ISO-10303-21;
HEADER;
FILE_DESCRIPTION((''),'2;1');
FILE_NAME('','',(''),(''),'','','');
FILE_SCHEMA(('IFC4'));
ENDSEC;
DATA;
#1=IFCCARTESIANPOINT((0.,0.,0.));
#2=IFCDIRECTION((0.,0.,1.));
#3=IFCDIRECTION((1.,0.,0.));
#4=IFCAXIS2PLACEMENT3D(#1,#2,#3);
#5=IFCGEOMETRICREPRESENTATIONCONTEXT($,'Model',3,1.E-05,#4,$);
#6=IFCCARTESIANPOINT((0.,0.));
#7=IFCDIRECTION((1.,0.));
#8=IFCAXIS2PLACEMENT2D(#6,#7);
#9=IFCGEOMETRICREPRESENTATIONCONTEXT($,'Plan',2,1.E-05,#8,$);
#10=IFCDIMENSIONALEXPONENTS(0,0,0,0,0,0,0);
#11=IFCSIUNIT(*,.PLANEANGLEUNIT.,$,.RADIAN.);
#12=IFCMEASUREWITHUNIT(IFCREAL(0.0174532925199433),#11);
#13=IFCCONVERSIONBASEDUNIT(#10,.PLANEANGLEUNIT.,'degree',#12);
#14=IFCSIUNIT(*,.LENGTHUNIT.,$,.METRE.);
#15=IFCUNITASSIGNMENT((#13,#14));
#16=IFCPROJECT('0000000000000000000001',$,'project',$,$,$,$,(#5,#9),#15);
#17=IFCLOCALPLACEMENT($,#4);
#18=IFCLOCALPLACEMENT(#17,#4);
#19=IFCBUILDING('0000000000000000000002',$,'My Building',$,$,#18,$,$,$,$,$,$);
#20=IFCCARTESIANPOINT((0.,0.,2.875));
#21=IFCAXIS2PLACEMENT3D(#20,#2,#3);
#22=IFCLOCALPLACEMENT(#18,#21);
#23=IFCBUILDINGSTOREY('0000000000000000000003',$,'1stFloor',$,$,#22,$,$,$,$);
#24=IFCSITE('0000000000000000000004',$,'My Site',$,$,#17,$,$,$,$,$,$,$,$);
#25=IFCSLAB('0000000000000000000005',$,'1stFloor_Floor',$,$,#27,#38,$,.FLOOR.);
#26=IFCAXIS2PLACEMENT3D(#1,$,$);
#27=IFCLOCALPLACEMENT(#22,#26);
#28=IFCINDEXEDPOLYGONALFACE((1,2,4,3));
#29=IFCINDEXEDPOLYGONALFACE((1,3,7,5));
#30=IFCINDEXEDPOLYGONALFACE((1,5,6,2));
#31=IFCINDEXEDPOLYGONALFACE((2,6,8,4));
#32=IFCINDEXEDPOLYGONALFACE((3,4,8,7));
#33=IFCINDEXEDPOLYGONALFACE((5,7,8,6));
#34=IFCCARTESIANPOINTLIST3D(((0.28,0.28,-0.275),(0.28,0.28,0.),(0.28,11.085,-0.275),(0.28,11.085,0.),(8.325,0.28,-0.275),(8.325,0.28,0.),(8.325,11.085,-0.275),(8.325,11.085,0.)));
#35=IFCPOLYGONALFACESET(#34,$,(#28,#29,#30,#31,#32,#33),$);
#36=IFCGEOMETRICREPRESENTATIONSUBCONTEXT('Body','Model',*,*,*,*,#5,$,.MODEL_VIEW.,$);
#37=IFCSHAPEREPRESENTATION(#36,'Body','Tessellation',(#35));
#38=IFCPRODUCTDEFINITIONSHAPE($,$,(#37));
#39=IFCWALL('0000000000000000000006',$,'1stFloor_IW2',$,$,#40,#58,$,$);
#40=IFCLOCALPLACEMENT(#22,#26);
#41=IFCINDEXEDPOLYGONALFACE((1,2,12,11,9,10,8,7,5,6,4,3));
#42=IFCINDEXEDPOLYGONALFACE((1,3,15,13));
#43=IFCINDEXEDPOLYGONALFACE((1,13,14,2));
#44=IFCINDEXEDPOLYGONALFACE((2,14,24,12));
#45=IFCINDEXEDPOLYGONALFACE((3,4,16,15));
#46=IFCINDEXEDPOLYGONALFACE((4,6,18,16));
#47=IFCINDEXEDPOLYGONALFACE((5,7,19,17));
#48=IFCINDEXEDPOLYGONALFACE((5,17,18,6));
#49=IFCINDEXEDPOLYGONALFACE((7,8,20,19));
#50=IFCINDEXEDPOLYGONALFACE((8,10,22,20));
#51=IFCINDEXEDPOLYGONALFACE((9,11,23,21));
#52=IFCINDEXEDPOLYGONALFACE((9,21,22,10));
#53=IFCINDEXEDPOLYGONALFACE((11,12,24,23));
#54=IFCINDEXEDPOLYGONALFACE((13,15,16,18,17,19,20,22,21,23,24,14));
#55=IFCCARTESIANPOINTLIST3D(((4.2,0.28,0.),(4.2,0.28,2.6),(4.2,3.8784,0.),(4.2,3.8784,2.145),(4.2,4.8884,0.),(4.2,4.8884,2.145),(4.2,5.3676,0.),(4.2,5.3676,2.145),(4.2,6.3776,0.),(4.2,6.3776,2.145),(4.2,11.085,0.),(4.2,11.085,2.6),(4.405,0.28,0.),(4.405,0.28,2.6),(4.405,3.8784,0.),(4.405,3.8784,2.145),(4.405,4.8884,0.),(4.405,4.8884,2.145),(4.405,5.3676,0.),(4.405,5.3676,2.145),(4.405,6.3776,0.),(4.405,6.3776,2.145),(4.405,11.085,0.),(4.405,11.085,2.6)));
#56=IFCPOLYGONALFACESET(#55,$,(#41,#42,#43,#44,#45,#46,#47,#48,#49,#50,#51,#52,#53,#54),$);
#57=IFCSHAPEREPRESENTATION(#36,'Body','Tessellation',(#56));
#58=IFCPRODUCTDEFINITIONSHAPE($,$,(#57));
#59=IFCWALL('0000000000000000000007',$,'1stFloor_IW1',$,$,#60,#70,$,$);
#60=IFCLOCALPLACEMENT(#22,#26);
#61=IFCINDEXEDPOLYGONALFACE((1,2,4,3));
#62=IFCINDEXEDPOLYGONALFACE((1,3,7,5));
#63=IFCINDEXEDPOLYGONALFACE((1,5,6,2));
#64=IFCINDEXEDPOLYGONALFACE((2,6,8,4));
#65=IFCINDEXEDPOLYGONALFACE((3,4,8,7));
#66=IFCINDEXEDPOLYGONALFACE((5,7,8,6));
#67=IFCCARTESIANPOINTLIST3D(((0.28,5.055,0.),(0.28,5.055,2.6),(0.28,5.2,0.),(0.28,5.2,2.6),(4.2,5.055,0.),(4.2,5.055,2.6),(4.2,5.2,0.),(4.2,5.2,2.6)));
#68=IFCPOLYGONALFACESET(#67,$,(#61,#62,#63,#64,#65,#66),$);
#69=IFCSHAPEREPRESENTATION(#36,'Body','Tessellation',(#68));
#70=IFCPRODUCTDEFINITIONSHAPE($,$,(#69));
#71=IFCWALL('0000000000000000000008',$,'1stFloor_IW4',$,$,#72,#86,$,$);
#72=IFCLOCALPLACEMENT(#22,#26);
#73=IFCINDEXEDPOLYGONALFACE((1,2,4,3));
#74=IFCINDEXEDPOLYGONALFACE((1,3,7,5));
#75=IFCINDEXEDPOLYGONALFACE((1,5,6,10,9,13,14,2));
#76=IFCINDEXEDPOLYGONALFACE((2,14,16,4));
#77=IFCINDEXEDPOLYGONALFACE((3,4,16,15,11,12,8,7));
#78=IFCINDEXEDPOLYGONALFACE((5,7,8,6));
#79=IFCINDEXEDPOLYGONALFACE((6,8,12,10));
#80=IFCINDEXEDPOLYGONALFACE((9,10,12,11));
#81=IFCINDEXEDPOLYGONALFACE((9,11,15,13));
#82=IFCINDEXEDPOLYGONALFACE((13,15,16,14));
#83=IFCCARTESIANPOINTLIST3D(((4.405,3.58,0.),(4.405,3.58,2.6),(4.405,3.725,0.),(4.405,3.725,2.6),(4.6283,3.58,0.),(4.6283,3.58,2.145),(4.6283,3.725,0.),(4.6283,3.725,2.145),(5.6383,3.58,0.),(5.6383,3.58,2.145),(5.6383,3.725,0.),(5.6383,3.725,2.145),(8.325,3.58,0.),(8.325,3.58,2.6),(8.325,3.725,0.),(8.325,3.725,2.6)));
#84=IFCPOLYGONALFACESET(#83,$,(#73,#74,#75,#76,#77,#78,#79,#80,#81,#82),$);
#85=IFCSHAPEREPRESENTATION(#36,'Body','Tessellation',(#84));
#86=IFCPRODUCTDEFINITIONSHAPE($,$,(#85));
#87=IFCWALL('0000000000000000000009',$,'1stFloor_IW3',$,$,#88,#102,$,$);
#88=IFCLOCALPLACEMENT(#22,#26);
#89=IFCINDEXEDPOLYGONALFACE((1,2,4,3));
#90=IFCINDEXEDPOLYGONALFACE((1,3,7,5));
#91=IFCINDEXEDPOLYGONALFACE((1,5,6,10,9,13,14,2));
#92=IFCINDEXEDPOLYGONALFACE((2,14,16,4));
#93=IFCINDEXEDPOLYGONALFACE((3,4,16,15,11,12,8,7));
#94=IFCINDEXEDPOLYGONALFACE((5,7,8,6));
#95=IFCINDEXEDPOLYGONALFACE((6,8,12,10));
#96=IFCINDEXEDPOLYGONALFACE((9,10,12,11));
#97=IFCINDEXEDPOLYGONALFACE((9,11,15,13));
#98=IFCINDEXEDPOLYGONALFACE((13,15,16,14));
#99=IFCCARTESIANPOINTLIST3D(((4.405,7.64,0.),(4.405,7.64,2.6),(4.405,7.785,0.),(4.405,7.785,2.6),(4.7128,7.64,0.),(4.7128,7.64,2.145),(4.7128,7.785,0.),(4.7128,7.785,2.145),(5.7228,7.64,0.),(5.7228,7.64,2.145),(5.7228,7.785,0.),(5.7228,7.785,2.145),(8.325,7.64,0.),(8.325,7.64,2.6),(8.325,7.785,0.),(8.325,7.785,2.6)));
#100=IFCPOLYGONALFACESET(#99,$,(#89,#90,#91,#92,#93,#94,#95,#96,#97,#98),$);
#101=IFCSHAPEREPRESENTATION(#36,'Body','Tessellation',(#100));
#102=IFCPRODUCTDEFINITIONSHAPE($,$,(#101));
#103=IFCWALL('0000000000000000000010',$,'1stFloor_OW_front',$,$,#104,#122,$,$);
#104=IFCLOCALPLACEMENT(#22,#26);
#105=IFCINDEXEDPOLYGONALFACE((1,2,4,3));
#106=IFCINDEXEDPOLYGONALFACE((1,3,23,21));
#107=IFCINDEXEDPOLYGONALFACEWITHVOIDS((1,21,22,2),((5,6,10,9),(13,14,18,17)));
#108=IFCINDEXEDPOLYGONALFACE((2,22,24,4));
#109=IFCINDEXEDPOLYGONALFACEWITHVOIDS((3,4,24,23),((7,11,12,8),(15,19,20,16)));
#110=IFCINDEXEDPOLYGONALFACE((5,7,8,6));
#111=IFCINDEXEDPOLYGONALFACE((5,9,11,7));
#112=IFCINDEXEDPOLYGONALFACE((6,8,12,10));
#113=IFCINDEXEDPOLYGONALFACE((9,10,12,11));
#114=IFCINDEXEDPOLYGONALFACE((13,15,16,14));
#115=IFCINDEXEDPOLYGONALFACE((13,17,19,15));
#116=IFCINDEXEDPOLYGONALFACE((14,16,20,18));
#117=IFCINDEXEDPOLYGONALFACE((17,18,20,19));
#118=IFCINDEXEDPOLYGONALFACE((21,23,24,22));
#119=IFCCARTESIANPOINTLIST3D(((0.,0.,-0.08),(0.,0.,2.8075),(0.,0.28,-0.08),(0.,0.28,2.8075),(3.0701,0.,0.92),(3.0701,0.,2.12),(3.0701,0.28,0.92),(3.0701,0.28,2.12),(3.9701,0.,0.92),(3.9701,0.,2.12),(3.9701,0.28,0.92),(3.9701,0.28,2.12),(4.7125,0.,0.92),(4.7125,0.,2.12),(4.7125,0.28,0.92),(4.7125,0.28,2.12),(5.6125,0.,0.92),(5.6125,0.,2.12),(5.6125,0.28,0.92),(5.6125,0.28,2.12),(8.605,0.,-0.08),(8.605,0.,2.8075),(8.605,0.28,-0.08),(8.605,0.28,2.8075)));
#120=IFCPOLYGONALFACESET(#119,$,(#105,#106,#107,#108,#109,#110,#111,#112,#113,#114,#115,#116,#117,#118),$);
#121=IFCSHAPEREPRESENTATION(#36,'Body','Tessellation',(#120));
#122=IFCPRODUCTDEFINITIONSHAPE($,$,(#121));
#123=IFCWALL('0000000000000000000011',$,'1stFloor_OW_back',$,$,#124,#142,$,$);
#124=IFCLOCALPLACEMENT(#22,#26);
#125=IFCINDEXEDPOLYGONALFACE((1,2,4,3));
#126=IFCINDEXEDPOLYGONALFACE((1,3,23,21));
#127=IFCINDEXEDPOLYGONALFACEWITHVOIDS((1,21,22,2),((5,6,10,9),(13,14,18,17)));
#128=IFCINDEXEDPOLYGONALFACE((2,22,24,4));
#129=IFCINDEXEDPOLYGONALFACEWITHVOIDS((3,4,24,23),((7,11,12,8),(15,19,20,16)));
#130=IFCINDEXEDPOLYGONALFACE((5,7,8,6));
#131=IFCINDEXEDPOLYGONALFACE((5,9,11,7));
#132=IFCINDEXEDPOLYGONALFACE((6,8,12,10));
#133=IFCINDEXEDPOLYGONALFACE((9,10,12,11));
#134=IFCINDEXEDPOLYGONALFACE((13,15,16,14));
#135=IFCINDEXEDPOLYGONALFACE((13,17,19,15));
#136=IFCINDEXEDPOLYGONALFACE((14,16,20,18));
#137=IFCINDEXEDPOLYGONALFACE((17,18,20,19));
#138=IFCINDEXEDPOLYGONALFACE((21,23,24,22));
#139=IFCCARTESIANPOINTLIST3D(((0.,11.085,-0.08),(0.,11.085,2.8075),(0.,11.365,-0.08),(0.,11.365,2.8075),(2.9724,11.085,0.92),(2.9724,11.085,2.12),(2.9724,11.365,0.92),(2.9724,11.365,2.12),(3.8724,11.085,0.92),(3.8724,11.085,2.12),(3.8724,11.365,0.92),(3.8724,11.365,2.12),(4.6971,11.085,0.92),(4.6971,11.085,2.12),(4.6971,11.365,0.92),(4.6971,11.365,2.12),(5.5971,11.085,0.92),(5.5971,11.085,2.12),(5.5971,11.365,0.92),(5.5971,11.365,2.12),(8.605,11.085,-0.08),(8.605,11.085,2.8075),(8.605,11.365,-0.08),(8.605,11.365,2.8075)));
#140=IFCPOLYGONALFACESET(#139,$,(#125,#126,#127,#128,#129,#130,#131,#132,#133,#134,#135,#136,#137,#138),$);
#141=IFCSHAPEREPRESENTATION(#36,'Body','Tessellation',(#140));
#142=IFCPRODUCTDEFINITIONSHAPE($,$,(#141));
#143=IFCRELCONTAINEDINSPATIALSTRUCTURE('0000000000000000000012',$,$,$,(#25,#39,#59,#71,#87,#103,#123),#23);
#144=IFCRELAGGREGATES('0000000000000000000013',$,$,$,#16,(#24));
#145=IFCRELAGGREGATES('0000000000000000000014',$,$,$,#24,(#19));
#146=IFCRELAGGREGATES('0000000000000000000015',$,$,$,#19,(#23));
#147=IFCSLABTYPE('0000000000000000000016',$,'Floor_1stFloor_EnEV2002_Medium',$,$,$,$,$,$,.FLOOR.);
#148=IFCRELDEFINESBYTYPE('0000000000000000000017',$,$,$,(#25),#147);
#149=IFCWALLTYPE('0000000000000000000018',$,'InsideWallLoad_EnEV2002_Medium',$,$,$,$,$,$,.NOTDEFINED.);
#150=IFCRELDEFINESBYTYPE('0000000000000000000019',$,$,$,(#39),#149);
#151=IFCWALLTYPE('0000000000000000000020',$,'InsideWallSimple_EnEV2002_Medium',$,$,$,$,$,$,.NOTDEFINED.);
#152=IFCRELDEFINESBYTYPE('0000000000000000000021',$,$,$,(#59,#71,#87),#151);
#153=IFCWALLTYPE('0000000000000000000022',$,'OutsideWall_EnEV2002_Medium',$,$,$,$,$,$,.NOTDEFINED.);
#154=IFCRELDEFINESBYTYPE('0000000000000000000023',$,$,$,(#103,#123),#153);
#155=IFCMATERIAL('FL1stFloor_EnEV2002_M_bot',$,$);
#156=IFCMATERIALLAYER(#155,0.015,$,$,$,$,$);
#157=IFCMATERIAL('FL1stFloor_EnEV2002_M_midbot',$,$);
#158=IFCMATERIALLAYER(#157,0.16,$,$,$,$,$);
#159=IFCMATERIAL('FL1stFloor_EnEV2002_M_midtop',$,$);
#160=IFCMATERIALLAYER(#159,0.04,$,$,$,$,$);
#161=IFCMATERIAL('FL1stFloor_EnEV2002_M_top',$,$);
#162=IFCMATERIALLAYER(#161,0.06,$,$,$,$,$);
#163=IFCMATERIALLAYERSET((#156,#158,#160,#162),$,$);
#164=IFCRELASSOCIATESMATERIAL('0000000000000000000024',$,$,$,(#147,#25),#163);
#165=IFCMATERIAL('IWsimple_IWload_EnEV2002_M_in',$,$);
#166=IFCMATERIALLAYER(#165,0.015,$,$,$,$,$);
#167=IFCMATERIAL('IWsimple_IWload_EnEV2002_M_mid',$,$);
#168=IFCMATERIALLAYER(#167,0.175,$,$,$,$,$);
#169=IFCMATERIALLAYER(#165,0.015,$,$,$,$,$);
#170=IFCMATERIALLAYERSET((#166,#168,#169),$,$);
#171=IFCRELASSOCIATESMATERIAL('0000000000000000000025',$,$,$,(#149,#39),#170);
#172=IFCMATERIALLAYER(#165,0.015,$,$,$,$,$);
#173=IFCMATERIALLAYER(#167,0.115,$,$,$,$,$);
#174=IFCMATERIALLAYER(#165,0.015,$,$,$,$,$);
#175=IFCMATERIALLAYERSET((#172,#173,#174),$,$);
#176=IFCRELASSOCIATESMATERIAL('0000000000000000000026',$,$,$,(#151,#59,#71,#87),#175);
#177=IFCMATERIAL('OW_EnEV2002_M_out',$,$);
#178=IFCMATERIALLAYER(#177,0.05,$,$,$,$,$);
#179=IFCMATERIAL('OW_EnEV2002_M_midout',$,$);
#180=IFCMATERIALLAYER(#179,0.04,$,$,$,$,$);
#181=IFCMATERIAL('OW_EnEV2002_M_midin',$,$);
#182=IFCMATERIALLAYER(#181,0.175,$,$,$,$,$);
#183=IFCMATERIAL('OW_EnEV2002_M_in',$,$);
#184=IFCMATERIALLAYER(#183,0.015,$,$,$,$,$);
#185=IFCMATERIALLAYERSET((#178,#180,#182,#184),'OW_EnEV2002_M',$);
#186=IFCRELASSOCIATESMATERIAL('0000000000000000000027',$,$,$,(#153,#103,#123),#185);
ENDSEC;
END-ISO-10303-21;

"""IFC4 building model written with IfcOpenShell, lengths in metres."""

from ifc_helpers import new_model, entity, si_unit, converted_unit, frame, origin_with_axes, origin_2d_with_axis, place, context, subcontext, project, spatial, line, indexed_curve, outline, extrude, source, transform, mapped, material, layer, layer_set, layer_usage, type_object, element, save


model = new_model("IFC4")

# Units and contexts
model_context = context("Model", 3, precision=1e-05, world=origin_with_axes())
plan_context = context("Plan", 2, precision=1e-05, world=origin_2d_with_axis())
body_context = subcontext(model_context, "Body", "Model", "MODEL_VIEW")
ifc_project = project(units=[converted_unit("PLANEANGLEUNIT", "degree", entity("IfcReal", 0.0174532925199433), si_unit("PLANEANGLEUNIT", "RADIAN"), dimensions=[0, 0, 0, 0, 0, 0, 0]), si_unit("LENGTHUNIT", "METRE")], contexts=[model_context, plan_context])

# Site, building, storey
site_placement = place(None, origin_with_axes())
site = spatial("IfcSite", under=ifc_project, at=site_placement, Name="My Site")
building_placement = place(site_placement, origin_with_axes())
building = spatial("IfcBuilding", under=site, at=building_placement, Name="My Building")
storey_placement = place(building_placement, frame((0.0, 0.0, 2.875), z_axis=(0.0, 0.0, 1.0), x_axis=(1.0, 0.0, 0.0)))
storey = spatial("IfcBuildingStorey", under=building, at=storey_placement, Name="1stFloor")

# Slab
ifc_material_1 = material(Name="FL1stFloor_EnEV2002_M_bot")
ifc_layer_1 = layer(ifc_material_1, 0.015)
ifc_material_2 = material(Name="FL1stFloor_EnEV2002_M_midbot")
ifc_layer_2 = layer(ifc_material_2, 0.16)
ifc_material_3 = material(Name="FL1stFloor_EnEV2002_M_midtop")
ifc_layer_3 = layer(ifc_material_3, 0.04)
ifc_material_4 = material(Name="FL1stFloor_EnEV2002_M_top")
ifc_layer_4 = layer(ifc_material_4, 0.06)
ifc_layer_set_1 = layer_set([ifc_layer_1, ifc_layer_2, ifc_layer_3, ifc_layer_4])
ifc_layer_usage_1 = layer_usage(ifc_layer_set_1, "AXIS3", "POSITIVE", 0.0)
slab_type = type_object("IfcSlabType", Name="Floor_1stFloor_EnEV2002_Medium", PredefinedType="FLOOR", material=ifc_layer_set_1)
slab_placement = place(storey_placement, frame((0.28, 0.28, -0.275), z_axis=(0.0, 0.0, 1.0), x_axis=(1.0, 0.0, 0.0)))
element("IfcSlab", 1, at=slab_placement, inside=storey, type_object=slab_type, material=ifc_layer_usage_1, Name="1stFloor_Floor", PredefinedType="FLOOR", context=body_context, shape_type="SweptSolid", body=[
    extrude(outline(indexed_curve([(0.0, 0.0), (8.045, 0.0), (8.045, 10.805), (0.0, 10.805)], segments=[line(4, 1), line(1, 2), line(2, 3), line(3, 4)], self_intersect=False)), None, (0.0, 0.0, 1.0), 0.275),
])

# Wall, openings
ifc_material_5 = material(Name="IWsimple_IWload_EnEV2002_M_in")
ifc_layer_5 = layer(ifc_material_5, 0.015)
ifc_material_6 = material(Name="IWsimple_IWload_EnEV2002_M_mid")
ifc_layer_6 = layer(ifc_material_6, 0.175)
ifc_layer_7 = layer(ifc_material_5, 0.015)
ifc_layer_set_2 = layer_set([ifc_layer_5, ifc_layer_6, ifc_layer_7])
ifc_layer_usage_2 = layer_usage(ifc_layer_set_2, "AXIS2", "POSITIVE", 0.0)
wall_type_1 = type_object("IfcWallType", Name="InsideWallLoad_EnEV2002_Medium", PredefinedType="NOTDEFINED", material=ifc_layer_set_2)
wall_1_placement = place(storey_placement, frame((4.405, 0.28, 0.0), z_axis=(0.0, 0.0, 1.0), x_axis=(0.0, 1.0, 0.0)))
wall_1 = element("IfcWall", 2, at=wall_1_placement, inside=storey, type_object=wall_type_1, material=ifc_layer_usage_2, Name="1stFloor_IW2", context=body_context, shape_type="SweptSolid", body=[
    extrude(outline(indexed_curve([(0.0, 0.0), (0.0, 0.205), (10.805, 0.205), (10.805, 0.0), (0.0, 0.0)], self_intersect=False)), origin_with_axes(), (0.0, 0.0, 1.0), 2.6),
])
shared_shape_1 = source(origin_with_axes(), body_context, "Body", "SweptSolid", [
    extrude(outline(indexed_curve([(0.0, 0.0), (1.01, 0.0), (1.01, 2.145), (0.0, 2.145)], segments=[line(1, 2, 3, 4, 1)])), frame((0.0, -0.1, 0.0), z_axis=(0.0, -1.0, 0.0), x_axis=(1.0, 0.0, 0.0)), (0.0, 0.0, -1.0), 0.48),
])
opening_1_placement = place(wall_1_placement, frame((3.5984, 0.0, 0.0), z_axis=(0.0, 0.0, 1.0), x_axis=(1.0, 0.0, 0.0)))
element("IfcOpeningElement", 3, at=opening_1_placement, cuts=wall_1, PredefinedType="OPENING", context=body_context, shape_type="MappedRepresentation", body=[
    mapped(shared_shape_1, transform((0.0, 0.0, 0.0), x_axis=(1.0, 0.0, 0.0), y_axis=(0.0, 1.0, 0.0), z_axis=(0.0, 0.0, 1.0), scale=1.0)),
])
opening_2_placement = place(wall_1_placement, frame((5.0876, 0.0, 0.0), z_axis=(0.0, 0.0, 1.0), x_axis=(1.0, 0.0, 0.0)))
element("IfcOpeningElement", 4, at=opening_2_placement, cuts=wall_1, PredefinedType="OPENING", context=body_context, shape_type="MappedRepresentation", body=[
    mapped(shared_shape_1, transform((0.0, 0.0, 0.0), x_axis=(1.0, 0.0, 0.0), y_axis=(0.0, 1.0, 0.0), z_axis=(0.0, 0.0, 1.0), scale=1.0)),
])

# Wall
ifc_layer_8 = layer(ifc_material_5, 0.015)
ifc_layer_9 = layer(ifc_material_6, 0.115)
ifc_layer_10 = layer(ifc_material_5, 0.015)
ifc_layer_set_3 = layer_set([ifc_layer_8, ifc_layer_9, ifc_layer_10])
ifc_layer_usage_3 = layer_usage(ifc_layer_set_3, "AXIS2", "POSITIVE", 0.0)
wall_type_2 = type_object("IfcWallType", Name="InsideWallSimple_EnEV2002_Medium", PredefinedType="NOTDEFINED", material=ifc_layer_set_3)
wall_2_placement = place(storey_placement, frame((0.28, 5.055, 0.0), z_axis=(0.0, 0.0, 1.0), x_axis=(1.0, 0.0, 0.0)))
element("IfcWall", 5, at=wall_2_placement, inside=storey, type_object=wall_type_2, material=ifc_layer_usage_3, Name="1stFloor_IW1", context=body_context, shape_type="SweptSolid", body=[
    extrude(outline(indexed_curve([(0.0, 0.0), (0.0, 0.145), (3.92, 0.145), (3.92, 0.0), (0.0, 0.0)], self_intersect=False)), origin_with_axes(), (0.0, 0.0, 1.0), 2.6),
])

# Walls, openings
ifc_layer_usage_4 = layer_usage(ifc_layer_set_3, "AXIS2", "POSITIVE", 0.0)
wall_3_placement = place(storey_placement, frame((4.405, 3.58, 0.0), z_axis=(0.0, 0.0, 1.0), x_axis=(1.0, 0.0, 0.0)))
wall_3 = element("IfcWall", 6, at=wall_3_placement, inside=storey, type_object=wall_type_2, material=ifc_layer_usage_4, Name="1stFloor_IW4", context=body_context, shape_type="SweptSolid", body=[
    extrude(outline(indexed_curve([(0.0, 0.0), (0.0, 0.145), (3.92, 0.145), (3.92, 0.0), (0.0, 0.0)], self_intersect=False)), origin_with_axes(), (0.0, 0.0, 1.0), 2.6),
])
opening_3_placement = place(wall_3_placement, frame((0.2233, 0.0, 0.0), z_axis=(0.0, 0.0, 1.0), x_axis=(1.0, 0.0, 0.0)))
element("IfcOpeningElement", 7, at=opening_3_placement, cuts=wall_3, PredefinedType="OPENING", context=body_context, shape_type="MappedRepresentation", body=[
    mapped(shared_shape_1, transform((0.0, 0.0, 0.0), x_axis=(1.0, 0.0, 0.0), y_axis=(0.0, 1.0, 0.0), z_axis=(0.0, 0.0, 1.0), scale=1.0)),
])
ifc_layer_usage_5 = layer_usage(ifc_layer_set_3, "AXIS2", "POSITIVE", 0.0)
wall_4_placement = place(storey_placement, frame((4.405, 7.64, 0.0), z_axis=(0.0, 0.0, 1.0), x_axis=(1.0, 0.0, 0.0)))
wall_4 = element("IfcWall", 8, at=wall_4_placement, inside=storey, type_object=wall_type_2, material=ifc_layer_usage_5, Name="1stFloor_IW3", context=body_context, shape_type="SweptSolid", body=[
    extrude(outline(indexed_curve([(0.0, 0.0), (0.0, 0.145), (3.92, 0.145), (3.92, 0.0), (0.0, 0.0)], self_intersect=False)), origin_with_axes(), (0.0, 0.0, 1.0), 2.6),
])
opening_4_placement = place(wall_4_placement, frame((0.3078, 0.0, 0.0), z_axis=(0.0, 0.0, 1.0), x_axis=(1.0, 0.0, 0.0)))
element("IfcOpeningElement", 9, at=opening_4_placement, cuts=wall_4, PredefinedType="OPENING", context=body_context, shape_type="MappedRepresentation", body=[
    mapped(shared_shape_1, transform((0.0, 0.0, 0.0), x_axis=(1.0, 0.0, 0.0), y_axis=(0.0, 1.0, 0.0), z_axis=(0.0, 0.0, 1.0), scale=1.0)),
])

# Walls, openings
ifc_material_7 = material(Name="OW_EnEV2002_M_out")
ifc_layer_11 = layer(ifc_material_7, 0.05)
ifc_material_8 = material(Name="OW_EnEV2002_M_midout")
ifc_layer_12 = layer(ifc_material_8, 0.04)
ifc_material_9 = material(Name="OW_EnEV2002_M_midin")
ifc_layer_13 = layer(ifc_material_9, 0.175)
ifc_material_10 = material(Name="OW_EnEV2002_M_in")
ifc_layer_14 = layer(ifc_material_10, 0.015)
ifc_layer_set_4 = layer_set([ifc_layer_11, ifc_layer_12, ifc_layer_13, ifc_layer_14], Name="OW_EnEV2002_M")
ifc_layer_usage_6 = layer_usage(ifc_layer_set_4, "AXIS2", "POSITIVE", 0.0)
wall_type_3 = type_object("IfcWallType", Name="OutsideWall_EnEV2002_Medium", PredefinedType="NOTDEFINED", material=ifc_layer_set_4)
wall_5_placement = place(storey_placement, frame((0.0, 0.0, -0.08), z_axis=(0.0, 0.0, 1.0), x_axis=(1.0, 0.0, 0.0)))
wall_5 = element("IfcWall", 10, at=wall_5_placement, inside=storey, type_object=wall_type_3, material=ifc_layer_usage_6, Name="1stFloor_OW_front", context=body_context, shape_type="SweptSolid", body=[
    extrude(outline(indexed_curve([(0.0, 0.0), (0.0, 0.28), (8.605, 0.28), (8.605, 0.0), (0.0, 0.0)], self_intersect=False)), origin_with_axes(), (0.0, 0.0, 1.0), 2.8875),
])
shared_shape_2 = source(origin_with_axes(), body_context, "Body", "SweptSolid", [
    extrude(outline(indexed_curve([(0.0, 0.0), (0.9, 0.0), (0.9, 1.2), (0.0, 1.2)], segments=[line(1, 2, 3, 4, 1)])), frame((0.0, -0.1, 0.0), z_axis=(0.0, -1.0, 0.0), x_axis=(1.0, 0.0, 0.0)), (0.0, 0.0, -1.0), 0.48),
])
opening_5_placement = place(wall_5_placement, frame((3.0701, 0.0, 1.0), z_axis=(0.0, 0.0, 1.0), x_axis=(1.0, 0.0, 0.0)))
element("IfcOpeningElement", 11, at=opening_5_placement, cuts=wall_5, PredefinedType="OPENING", context=body_context, shape_type="MappedRepresentation", body=[
    mapped(shared_shape_2, transform((0.0, 0.0, 0.0), x_axis=(1.0, 0.0, 0.0), y_axis=(0.0, 1.0, 0.0), z_axis=(0.0, 0.0, 1.0), scale=1.0)),
])
opening_6_placement = place(wall_5_placement, frame((4.7125, 0.0, 1.0), z_axis=(0.0, 0.0, 1.0), x_axis=(1.0, 0.0, 0.0)))
element("IfcOpeningElement", 12, at=opening_6_placement, cuts=wall_5, PredefinedType="OPENING", context=body_context, shape_type="MappedRepresentation", body=[
    mapped(shared_shape_2, transform((0.0, 0.0, 0.0), x_axis=(1.0, 0.0, 0.0), y_axis=(0.0, 1.0, 0.0), z_axis=(0.0, 0.0, 1.0), scale=1.0)),
])
ifc_layer_usage_7 = layer_usage(ifc_layer_set_4, "AXIS2", "POSITIVE", 0.0)
wall_6_placement = place(storey_placement, frame((8.605, 11.365, -0.08), z_axis=(0.0, 0.0, 1.0), x_axis=(-1.0, 0.0, 0.0)))
wall_6 = element("IfcWall", 13, at=wall_6_placement, inside=storey, type_object=wall_type_3, material=ifc_layer_usage_7, Name="1stFloor_OW_back", context=body_context, shape_type="SweptSolid", body=[
    extrude(outline(indexed_curve([(0.0, 0.0), (0.0, 0.28), (8.605, 0.28), (8.605, 0.0), (0.0, 0.0)], self_intersect=False)), origin_with_axes(), (0.0, 0.0, 1.0), 2.8875),
])
opening_7_placement = place(wall_6_placement, frame((3.0079, 0.0, 1.0), z_axis=(0.0, 0.0, 1.0), x_axis=(1.0, 0.0, 0.0)))
element("IfcOpeningElement", 14, at=opening_7_placement, cuts=wall_6, PredefinedType="OPENING", context=body_context, shape_type="MappedRepresentation", body=[
    mapped(shared_shape_2, transform((0.0, 0.0, 0.0), x_axis=(1.0, 0.0, 0.0), y_axis=(0.0, 1.0, 0.0), z_axis=(0.0, 0.0, 1.0), scale=1.0)),
])
opening_8_placement = place(wall_6_placement, frame((4.7326, 0.0, 1.0), z_axis=(0.0, 0.0, 1.0), x_axis=(1.0, 0.0, 0.0)))
element("IfcOpeningElement", 15, at=opening_8_placement, cuts=wall_6, PredefinedType="OPENING", context=body_context, shape_type="MappedRepresentation", body=[
    mapped(shared_shape_2, transform((0.0, 0.0, 0.0), x_axis=(1.0, 0.0, 0.0), y_axis=(0.0, 1.0, 0.0), z_axis=(0.0, 0.0, 1.0), scale=1.0)),
])

save(model, "model.ifc")
